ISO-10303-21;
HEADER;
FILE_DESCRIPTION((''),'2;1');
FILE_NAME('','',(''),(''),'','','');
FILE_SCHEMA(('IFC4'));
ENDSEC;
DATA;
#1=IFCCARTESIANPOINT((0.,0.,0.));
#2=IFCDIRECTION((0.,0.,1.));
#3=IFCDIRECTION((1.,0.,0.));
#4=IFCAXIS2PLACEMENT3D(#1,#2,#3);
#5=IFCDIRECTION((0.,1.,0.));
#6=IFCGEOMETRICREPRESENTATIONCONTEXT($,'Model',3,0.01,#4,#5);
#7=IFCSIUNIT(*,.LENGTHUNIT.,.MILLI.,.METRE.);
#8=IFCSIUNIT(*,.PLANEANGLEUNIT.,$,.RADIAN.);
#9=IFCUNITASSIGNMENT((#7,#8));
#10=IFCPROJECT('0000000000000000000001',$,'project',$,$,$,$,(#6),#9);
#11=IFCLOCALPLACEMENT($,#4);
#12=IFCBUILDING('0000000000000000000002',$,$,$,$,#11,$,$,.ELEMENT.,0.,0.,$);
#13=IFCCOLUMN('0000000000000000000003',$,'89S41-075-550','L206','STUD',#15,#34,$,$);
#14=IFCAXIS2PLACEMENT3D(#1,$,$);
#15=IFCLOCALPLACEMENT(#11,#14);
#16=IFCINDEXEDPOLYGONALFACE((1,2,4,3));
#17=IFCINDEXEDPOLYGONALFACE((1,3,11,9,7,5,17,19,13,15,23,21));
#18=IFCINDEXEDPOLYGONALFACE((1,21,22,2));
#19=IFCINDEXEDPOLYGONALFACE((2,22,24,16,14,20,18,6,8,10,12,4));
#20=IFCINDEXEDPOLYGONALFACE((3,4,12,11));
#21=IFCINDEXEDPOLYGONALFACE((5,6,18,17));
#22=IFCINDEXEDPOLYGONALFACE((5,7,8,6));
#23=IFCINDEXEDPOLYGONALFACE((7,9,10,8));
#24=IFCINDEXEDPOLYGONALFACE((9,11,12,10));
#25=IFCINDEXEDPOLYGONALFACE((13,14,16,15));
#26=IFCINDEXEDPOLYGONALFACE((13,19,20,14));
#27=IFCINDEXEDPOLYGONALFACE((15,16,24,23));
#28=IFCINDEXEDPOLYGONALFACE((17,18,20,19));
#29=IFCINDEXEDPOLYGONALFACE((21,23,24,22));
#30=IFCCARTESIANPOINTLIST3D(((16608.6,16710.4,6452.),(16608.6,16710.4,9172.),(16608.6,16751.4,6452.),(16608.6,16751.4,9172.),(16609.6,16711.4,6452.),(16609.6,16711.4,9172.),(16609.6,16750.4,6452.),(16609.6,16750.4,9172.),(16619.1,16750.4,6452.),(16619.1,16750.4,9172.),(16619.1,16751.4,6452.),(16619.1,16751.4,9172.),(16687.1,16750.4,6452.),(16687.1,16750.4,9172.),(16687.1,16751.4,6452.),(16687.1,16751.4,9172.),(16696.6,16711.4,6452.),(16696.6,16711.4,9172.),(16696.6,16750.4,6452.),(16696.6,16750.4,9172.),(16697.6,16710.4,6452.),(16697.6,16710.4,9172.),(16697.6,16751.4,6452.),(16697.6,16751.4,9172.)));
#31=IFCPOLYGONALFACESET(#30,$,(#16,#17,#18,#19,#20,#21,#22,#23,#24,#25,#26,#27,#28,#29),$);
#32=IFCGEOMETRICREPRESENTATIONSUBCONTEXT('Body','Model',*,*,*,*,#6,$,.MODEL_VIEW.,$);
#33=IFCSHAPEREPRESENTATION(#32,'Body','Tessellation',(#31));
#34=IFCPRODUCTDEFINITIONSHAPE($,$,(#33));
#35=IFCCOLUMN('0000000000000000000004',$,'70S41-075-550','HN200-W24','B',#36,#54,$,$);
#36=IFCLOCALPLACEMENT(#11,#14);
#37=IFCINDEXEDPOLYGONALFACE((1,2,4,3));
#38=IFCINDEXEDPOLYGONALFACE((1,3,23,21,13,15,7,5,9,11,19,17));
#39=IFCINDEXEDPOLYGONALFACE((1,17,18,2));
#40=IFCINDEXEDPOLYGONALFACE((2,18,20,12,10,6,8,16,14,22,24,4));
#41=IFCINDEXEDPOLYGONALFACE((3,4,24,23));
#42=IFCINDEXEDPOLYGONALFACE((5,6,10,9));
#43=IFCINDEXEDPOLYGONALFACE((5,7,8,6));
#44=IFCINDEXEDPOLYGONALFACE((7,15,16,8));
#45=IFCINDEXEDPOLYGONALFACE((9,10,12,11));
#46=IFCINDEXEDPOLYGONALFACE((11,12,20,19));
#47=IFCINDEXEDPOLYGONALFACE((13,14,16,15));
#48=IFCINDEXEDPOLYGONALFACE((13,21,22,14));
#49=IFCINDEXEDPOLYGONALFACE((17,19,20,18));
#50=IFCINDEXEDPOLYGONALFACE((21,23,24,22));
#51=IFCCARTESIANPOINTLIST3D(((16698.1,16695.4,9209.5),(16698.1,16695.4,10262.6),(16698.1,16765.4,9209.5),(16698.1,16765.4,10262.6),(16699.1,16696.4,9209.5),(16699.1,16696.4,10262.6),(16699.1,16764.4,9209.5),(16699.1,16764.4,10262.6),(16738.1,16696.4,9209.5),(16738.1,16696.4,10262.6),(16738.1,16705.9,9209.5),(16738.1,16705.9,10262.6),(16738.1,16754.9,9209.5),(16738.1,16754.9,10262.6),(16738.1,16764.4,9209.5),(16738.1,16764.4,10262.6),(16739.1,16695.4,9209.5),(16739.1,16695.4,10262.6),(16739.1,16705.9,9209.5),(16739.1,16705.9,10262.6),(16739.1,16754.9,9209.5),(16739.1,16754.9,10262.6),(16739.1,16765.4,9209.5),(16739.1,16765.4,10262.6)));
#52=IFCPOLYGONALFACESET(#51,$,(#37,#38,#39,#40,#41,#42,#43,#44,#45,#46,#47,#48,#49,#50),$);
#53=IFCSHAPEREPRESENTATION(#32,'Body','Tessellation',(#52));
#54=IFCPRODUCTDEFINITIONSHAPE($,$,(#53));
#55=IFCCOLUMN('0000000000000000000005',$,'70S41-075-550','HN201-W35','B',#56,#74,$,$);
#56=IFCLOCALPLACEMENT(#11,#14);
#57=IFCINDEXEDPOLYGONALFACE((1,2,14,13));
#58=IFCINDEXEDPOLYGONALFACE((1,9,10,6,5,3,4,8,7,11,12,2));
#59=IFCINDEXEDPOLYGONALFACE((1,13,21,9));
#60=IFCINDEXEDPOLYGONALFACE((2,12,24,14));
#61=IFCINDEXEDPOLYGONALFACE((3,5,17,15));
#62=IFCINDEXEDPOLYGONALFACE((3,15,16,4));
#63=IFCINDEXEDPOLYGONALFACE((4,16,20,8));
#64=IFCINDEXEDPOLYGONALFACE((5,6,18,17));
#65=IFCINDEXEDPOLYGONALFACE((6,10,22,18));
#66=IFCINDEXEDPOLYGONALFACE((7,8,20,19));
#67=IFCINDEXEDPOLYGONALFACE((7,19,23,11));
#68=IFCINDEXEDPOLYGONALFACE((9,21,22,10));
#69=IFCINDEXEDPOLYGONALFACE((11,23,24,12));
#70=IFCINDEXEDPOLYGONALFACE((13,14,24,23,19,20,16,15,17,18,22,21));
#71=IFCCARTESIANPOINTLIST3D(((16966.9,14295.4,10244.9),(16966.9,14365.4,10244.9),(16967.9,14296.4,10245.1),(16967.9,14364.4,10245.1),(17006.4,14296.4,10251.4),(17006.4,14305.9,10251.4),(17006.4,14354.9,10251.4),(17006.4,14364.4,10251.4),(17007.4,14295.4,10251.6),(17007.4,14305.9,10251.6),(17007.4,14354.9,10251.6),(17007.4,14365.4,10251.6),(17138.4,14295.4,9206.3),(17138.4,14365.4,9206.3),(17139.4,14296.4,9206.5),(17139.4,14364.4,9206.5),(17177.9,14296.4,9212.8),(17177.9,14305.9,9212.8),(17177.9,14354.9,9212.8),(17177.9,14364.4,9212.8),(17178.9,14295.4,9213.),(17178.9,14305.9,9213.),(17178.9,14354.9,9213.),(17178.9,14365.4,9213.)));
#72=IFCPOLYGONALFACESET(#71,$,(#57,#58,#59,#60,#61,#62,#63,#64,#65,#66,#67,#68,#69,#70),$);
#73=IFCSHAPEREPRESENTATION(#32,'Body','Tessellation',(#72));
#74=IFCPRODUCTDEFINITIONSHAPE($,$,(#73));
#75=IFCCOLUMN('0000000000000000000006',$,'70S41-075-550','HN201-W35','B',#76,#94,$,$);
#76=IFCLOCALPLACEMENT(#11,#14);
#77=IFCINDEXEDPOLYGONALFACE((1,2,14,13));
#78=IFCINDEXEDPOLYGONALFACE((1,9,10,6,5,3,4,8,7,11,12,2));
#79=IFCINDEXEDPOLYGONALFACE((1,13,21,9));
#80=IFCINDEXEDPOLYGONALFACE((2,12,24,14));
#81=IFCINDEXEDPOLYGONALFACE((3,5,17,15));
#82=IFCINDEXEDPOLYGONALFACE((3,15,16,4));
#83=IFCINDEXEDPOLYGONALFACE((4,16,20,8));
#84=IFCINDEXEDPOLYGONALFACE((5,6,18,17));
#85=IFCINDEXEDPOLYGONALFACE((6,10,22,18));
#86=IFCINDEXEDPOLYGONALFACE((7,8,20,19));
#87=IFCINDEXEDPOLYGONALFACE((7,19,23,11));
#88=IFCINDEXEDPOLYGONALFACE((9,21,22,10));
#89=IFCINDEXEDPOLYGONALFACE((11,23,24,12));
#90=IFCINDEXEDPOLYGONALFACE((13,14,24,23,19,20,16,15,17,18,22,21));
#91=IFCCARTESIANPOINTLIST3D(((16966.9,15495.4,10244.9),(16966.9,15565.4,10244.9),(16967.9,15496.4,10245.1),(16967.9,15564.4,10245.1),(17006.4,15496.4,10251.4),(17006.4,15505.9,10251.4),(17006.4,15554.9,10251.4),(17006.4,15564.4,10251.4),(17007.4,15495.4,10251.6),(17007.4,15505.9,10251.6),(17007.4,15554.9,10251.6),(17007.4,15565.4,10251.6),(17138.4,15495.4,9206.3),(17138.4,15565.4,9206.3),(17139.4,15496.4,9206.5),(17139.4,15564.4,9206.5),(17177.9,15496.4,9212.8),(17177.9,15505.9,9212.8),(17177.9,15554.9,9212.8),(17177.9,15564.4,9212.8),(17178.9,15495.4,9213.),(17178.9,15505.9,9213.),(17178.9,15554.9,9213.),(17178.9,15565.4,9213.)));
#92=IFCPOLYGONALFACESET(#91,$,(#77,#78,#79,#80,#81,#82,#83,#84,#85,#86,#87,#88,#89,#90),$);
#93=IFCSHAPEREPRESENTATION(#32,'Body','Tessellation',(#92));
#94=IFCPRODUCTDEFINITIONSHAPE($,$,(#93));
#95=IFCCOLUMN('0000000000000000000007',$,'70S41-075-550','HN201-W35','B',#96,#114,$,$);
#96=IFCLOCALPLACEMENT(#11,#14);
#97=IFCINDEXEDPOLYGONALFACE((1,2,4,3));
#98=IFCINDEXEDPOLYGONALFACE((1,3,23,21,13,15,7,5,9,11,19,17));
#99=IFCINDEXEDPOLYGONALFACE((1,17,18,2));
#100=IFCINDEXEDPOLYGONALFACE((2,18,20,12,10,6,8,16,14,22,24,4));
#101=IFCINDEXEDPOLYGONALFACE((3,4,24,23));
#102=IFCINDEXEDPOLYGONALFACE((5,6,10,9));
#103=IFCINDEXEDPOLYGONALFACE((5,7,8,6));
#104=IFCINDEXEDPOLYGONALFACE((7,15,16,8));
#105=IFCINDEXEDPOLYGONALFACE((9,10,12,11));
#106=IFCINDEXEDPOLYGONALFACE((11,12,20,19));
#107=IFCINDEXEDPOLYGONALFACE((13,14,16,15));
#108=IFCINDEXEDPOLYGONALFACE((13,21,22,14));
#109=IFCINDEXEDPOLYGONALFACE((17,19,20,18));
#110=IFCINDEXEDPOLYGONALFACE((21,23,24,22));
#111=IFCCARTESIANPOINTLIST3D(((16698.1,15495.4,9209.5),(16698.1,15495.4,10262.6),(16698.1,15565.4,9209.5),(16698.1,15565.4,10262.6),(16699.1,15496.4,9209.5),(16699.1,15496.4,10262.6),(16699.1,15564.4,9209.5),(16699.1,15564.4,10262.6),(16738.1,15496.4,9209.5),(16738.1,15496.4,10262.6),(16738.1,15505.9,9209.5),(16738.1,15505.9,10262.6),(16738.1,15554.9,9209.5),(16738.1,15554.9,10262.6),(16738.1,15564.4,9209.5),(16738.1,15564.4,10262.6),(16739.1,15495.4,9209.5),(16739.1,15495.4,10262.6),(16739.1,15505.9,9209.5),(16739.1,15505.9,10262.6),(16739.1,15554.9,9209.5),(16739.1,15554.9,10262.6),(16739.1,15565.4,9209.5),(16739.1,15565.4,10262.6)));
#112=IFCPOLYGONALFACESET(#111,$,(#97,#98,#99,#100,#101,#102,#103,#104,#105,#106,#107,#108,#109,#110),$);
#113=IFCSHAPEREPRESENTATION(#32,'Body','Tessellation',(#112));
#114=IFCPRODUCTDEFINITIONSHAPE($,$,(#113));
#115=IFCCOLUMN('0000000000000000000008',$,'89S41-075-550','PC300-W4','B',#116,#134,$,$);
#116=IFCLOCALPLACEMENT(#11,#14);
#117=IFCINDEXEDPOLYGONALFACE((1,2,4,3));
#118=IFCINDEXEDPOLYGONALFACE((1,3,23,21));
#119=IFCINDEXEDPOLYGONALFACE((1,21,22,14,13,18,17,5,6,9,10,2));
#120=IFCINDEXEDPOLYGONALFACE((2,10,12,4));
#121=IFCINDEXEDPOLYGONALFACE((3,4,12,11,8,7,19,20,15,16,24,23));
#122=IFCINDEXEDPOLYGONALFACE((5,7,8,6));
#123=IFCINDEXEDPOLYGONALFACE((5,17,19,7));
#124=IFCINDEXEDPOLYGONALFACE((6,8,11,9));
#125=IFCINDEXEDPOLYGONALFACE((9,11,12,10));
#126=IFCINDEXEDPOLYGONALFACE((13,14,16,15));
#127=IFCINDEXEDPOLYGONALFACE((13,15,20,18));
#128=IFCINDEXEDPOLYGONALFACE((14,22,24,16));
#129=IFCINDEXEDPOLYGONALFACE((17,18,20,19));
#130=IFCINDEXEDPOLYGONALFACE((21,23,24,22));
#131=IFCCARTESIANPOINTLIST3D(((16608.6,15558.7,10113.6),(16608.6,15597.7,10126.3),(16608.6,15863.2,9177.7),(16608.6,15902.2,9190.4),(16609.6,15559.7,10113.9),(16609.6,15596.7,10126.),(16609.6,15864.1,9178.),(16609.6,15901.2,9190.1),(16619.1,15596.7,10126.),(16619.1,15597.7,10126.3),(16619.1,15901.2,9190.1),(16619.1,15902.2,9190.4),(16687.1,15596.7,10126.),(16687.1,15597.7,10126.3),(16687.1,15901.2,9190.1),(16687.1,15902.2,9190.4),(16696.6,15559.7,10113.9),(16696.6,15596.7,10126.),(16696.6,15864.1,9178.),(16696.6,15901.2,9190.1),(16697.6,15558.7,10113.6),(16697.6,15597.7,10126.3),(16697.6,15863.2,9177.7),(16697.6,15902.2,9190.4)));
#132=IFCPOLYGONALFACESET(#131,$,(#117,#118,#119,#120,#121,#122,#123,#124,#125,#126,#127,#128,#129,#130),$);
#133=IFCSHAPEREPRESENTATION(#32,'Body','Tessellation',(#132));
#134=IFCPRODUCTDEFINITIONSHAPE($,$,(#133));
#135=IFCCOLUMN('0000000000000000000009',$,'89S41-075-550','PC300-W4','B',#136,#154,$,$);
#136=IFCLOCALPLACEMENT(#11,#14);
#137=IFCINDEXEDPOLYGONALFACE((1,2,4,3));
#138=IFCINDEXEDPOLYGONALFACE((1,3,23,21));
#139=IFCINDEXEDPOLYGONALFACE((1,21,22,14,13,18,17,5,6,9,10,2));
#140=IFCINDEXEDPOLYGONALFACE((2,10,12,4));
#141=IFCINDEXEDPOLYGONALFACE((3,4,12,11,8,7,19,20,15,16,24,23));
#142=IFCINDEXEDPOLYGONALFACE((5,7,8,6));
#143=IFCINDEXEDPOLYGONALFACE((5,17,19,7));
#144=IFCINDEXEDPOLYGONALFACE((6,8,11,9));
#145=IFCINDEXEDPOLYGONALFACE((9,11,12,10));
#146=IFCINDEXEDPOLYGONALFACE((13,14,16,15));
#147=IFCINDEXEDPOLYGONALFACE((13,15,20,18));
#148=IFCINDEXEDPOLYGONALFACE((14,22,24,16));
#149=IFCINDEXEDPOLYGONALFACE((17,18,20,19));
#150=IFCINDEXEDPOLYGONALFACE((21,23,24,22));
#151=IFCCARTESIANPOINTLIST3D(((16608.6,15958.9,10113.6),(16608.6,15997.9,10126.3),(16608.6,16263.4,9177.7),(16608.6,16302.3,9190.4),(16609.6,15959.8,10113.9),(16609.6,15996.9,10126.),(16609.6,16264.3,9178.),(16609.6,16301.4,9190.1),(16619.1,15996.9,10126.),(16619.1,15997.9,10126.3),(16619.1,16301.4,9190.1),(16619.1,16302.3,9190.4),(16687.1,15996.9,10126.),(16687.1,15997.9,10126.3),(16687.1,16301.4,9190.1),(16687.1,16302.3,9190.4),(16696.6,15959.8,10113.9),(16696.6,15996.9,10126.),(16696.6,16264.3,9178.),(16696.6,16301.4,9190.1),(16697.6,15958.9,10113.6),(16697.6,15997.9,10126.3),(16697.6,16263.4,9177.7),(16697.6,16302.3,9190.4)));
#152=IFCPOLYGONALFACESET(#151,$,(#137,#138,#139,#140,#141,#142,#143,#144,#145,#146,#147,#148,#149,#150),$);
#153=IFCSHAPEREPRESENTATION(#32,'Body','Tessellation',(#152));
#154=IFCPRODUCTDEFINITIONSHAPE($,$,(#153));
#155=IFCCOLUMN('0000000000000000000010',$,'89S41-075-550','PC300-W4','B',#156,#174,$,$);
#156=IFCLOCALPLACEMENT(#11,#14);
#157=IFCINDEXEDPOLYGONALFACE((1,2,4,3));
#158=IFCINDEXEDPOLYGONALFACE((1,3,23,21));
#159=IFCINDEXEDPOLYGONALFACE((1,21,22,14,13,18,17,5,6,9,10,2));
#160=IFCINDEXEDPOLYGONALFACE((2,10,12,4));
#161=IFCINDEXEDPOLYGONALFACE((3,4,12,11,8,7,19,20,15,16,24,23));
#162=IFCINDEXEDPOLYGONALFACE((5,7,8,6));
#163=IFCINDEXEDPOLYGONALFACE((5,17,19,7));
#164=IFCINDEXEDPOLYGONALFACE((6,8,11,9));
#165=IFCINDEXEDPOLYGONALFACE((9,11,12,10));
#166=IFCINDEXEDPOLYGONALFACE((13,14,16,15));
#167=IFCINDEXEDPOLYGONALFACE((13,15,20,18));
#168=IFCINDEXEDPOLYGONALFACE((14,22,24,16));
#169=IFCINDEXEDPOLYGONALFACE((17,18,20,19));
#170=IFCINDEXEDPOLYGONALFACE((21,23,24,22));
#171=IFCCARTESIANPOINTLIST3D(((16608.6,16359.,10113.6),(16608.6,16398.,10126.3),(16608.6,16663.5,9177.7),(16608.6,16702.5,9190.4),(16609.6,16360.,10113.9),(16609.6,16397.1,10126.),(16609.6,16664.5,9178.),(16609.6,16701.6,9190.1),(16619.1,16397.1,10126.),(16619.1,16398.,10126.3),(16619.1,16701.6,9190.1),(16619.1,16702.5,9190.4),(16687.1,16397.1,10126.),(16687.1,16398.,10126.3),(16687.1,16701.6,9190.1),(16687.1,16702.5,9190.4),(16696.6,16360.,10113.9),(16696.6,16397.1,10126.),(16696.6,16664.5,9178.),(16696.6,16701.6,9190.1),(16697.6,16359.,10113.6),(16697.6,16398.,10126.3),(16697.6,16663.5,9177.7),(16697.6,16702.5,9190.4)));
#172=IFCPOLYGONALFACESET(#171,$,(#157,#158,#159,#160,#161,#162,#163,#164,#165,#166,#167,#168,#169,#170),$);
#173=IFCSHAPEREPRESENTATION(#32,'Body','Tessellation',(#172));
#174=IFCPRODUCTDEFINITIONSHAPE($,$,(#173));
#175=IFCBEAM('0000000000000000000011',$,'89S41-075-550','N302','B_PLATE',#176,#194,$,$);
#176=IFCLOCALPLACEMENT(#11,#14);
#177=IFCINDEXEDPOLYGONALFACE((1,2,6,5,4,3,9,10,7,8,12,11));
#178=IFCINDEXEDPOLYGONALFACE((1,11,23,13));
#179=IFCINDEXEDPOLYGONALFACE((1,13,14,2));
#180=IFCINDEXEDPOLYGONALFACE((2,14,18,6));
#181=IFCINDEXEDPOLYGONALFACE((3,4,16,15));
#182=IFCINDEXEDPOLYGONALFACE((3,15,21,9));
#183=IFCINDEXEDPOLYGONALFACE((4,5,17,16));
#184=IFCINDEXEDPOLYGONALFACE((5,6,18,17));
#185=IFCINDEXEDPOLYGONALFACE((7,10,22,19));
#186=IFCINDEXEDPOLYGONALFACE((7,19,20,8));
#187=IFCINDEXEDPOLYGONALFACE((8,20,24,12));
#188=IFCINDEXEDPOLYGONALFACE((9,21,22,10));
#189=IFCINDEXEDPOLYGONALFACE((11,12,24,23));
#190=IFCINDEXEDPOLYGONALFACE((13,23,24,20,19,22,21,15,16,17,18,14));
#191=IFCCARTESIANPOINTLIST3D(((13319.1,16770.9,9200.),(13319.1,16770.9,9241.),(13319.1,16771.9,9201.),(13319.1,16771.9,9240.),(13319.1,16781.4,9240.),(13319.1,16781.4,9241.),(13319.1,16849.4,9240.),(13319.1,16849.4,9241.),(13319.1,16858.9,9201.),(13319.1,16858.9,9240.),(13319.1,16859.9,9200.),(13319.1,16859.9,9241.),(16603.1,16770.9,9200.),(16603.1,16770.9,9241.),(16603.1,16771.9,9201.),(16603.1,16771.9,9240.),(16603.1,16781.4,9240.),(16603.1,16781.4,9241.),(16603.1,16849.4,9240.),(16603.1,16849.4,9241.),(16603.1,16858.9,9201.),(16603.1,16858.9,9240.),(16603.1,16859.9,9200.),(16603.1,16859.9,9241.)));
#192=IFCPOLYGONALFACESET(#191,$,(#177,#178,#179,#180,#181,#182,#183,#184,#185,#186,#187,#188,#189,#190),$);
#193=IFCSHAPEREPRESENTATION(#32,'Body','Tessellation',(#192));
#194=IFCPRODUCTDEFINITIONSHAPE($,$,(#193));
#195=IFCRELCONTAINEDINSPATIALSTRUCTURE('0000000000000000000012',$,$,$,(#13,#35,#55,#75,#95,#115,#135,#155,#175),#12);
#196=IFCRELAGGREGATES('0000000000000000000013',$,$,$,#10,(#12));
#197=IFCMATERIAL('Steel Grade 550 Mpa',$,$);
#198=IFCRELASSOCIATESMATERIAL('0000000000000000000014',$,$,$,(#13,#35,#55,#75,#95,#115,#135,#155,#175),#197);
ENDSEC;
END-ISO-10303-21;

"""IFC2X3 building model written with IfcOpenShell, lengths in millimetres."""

from ifc_helpers import new_model, si_unit, direction, frame, origin, origin_with_axes, origin_2d_with_axis, place, context, subcontext, project, spatial, c_section, extrude, source, transform, mapped, material, element, save


model = new_model("IFC2X3")

# Units and contexts
model_context = context("Model", 3, precision=0.01, world=origin_with_axes(), true_north=direction((0.0, 1.0, 0.0)))
body_context = subcontext(model_context, "Body", "Model", "MODEL_VIEW")
ifc_project = project(units=[si_unit("LENGTHUNIT", "METRE", prefix="MILLI"), si_unit("PLANEANGLEUNIT", "RADIAN")], contexts=[model_context])

# Building
building_placement = place(None, origin_with_axes())
building = spatial("IfcBuilding", under=ifc_project, at=building_placement, CompositionType="ELEMENT", ElevationOfRefHeight=0.0, ElevationOfTerrain=0.0)

# Columns
ifc_material = material(Name="Steel Grade 550 Mpa")
shared_shape_1 = source(origin(), body_context, "Body", "SweptSolid", [
    extrude(c_section(Depth=89.0, Width=41.0, WallThickness=1.0, Girth=10.5, at=origin_2d_with_axis()), origin_with_axes(), (0.0, 0.0, 1.0), 2720.0),
])
column_1_placement = place(None, frame((16653.1, 16730.9, 6452.0), z_axis=(0.0, 0.0, 1.0), x_axis=(0.0, 1.0, 0.0)))
element("IfcColumn", 1, at=column_1_placement, inside=building, material=ifc_material, Name="89S41-075-550", Description="L206", ObjectType="STUD", context=body_context, shape_type="MappedRepresentation", body=[
    mapped(shared_shape_1, transform((0.0, 0.0, 0.0), scale=1.0)),
])
shared_shape_2 = source(origin(), body_context, "Body", "SweptSolid", [
    extrude(c_section(Depth=70.0, Width=41.0, WallThickness=1.0, Girth=10.5, at=origin_2d_with_axis()), origin_with_axes(), (0.0, 0.0, 1.0), 1053.1),
])
column_2_placement = place(None, frame((16718.6, 16730.4, 9209.5), z_axis=(0.0, 0.0, 1.0), x_axis=(1.0, 0.0, 0.0)))
element("IfcColumn", 2, at=column_2_placement, inside=building, material=ifc_material, Name="70S41-075-550", Description="HN200-W24", ObjectType="B", context=body_context, shape_type="MappedRepresentation", body=[
    mapped(shared_shape_2, transform((0.0, 0.0, 0.0), scale=1.0)),
])
shared_shape_3 = source(origin(), body_context, "Body", "SweptSolid", [
    extrude(c_section(Depth=70.0, Width=41.0, WallThickness=1.0, Girth=10.5, at=origin_2d_with_axis()), origin_with_axes(), (0.0, 0.0, 1.0), 1052.7),
])
column_3_placement = place(None, frame((17158.7, 14330.4, 9209.6), z_axis=(-0.162913, 0.0, 0.98664), x_axis=(0.98664, 0.0, 0.162913)))
element("IfcColumn", 3, at=column_3_placement, inside=building, material=ifc_material, Name="70S41-075-550", Description="HN201-W35", ObjectType="B", context=body_context, shape_type="MappedRepresentation", body=[
    mapped(shared_shape_3, transform((0.0, 0.0, 0.0), scale=1.0)),
])
shared_shape_4 = source(origin(), body_context, "Body", "SweptSolid", [
    extrude(c_section(Depth=70.0, Width=41.0, WallThickness=1.0, Girth=10.5, at=origin_2d_with_axis()), origin_with_axes(), (0.0, 0.0, 1.0), 1052.7),
])
column_4_placement = place(None, frame((17158.7, 15530.4, 9209.6), z_axis=(-0.162913, 0.0, 0.98664), x_axis=(0.98664, 0.0, 0.162913)))
element("IfcColumn", 4, at=column_4_placement, inside=building, material=ifc_material, Name="70S41-075-550", Description="HN201-W35", ObjectType="B", context=body_context, shape_type="MappedRepresentation", body=[
    mapped(shared_shape_4, transform((0.0, 0.0, 0.0), scale=1.0)),
])
shared_shape_5 = source(origin(), body_context, "Body", "SweptSolid", [
    extrude(c_section(Depth=70.0, Width=41.0, WallThickness=1.0, Girth=10.5, at=origin_2d_with_axis()), origin_with_axes(), (0.0, 0.0, 1.0), 1053.1),
])
column_5_placement = place(None, frame((16718.6, 15530.4, 9209.5), z_axis=(0.0, 0.0, 1.0), x_axis=(1.0, 0.0, 0.0)))
element("IfcColumn", 5, at=column_5_placement, inside=building, material=ifc_material, Name="70S41-075-550", Description="HN201-W35", ObjectType="B", context=body_context, shape_type="MappedRepresentation", body=[
    mapped(shared_shape_5, transform((0.0, 0.0, 0.0), scale=1.0)),
])
shared_shape_6 = source(origin(), body_context, "Body", "SweptSolid", [
    extrude(c_section(Depth=89.0, Width=41.0, WallThickness=1.0, Girth=10.5, at=origin_2d_with_axis()), origin_with_axes(), (0.0, 0.0, 1.0), 984.2),
])
column_6_placement = place(None, frame((16653.1, 15882.7, 9184.0), z_axis=(0.0, -0.30936, 0.950945), x_axis=(0.0, 0.950945, 0.30936)))
element("IfcColumn", 6, at=column_6_placement, inside=building, material=ifc_material, Name="89S41-075-550", Description="PC300-W4", ObjectType="B", context=body_context, shape_type="MappedRepresentation", body=[
    mapped(shared_shape_6, transform((0.0, 0.0, 0.0), scale=1.0)),
])
shared_shape_7 = source(origin(), body_context, "Body", "SweptSolid", [
    extrude(c_section(Depth=89.0, Width=41.0, WallThickness=1.0, Girth=10.5, at=origin_2d_with_axis()), origin_with_axes(), (0.0, 0.0, 1.0), 984.2),
])
column_7_placement = place(None, frame((16653.1, 16282.8, 9184.0), z_axis=(0.0, -0.30936, 0.950945), x_axis=(0.0, 0.950945, 0.30936)))
element("IfcColumn", 7, at=column_7_placement, inside=building, material=ifc_material, Name="89S41-075-550", Description="PC300-W4", ObjectType="B", context=body_context, shape_type="MappedRepresentation", body=[
    mapped(shared_shape_7, transform((0.0, 0.0, 0.0), scale=1.0)),
])
shared_shape_8 = source(origin(), body_context, "Body", "SweptSolid", [
    extrude(c_section(Depth=89.0, Width=41.0, WallThickness=1.0, Girth=10.5, at=origin_2d_with_axis()), origin_with_axes(), (0.0, 0.0, 1.0), 984.2),
])
column_8_placement = place(None, frame((16653.1, 16683.0, 9184.0), z_axis=(0.0, -0.30936, 0.950945), x_axis=(0.0, 0.950945, 0.30936)))
element("IfcColumn", 8, at=column_8_placement, inside=building, material=ifc_material, Name="89S41-075-550", Description="PC300-W4", ObjectType="B", context=body_context, shape_type="MappedRepresentation", body=[
    mapped(shared_shape_8, transform((0.0, 0.0, 0.0), scale=1.0)),
])

# Beam
shared_shape_9 = source(origin(), body_context, "Body", "SweptSolid", [
    extrude(c_section(Depth=89.0, Width=41.0, WallThickness=1.0, Girth=10.5, at=origin_2d_with_axis()), origin_with_axes(), (0.0, 0.0, 1.0), 3284.0),
])
beam_1_placement = place(None, frame((16603.1, 16815.4, 9220.5), z_axis=(-1.0, 0.0, 0.0), x_axis=(0.0, 0.0, 1.0)))
element("IfcBeam", 9, at=beam_1_placement, inside=building, material=ifc_material, Name="89S41-075-550", Description="N302", ObjectType="B_PLATE", context=body_context, shape_type="MappedRepresentation", body=[
    mapped(shared_shape_9, transform((0.0, 0.0, 0.0), scale=1.0)),
])

save(model, "model.ifc")
